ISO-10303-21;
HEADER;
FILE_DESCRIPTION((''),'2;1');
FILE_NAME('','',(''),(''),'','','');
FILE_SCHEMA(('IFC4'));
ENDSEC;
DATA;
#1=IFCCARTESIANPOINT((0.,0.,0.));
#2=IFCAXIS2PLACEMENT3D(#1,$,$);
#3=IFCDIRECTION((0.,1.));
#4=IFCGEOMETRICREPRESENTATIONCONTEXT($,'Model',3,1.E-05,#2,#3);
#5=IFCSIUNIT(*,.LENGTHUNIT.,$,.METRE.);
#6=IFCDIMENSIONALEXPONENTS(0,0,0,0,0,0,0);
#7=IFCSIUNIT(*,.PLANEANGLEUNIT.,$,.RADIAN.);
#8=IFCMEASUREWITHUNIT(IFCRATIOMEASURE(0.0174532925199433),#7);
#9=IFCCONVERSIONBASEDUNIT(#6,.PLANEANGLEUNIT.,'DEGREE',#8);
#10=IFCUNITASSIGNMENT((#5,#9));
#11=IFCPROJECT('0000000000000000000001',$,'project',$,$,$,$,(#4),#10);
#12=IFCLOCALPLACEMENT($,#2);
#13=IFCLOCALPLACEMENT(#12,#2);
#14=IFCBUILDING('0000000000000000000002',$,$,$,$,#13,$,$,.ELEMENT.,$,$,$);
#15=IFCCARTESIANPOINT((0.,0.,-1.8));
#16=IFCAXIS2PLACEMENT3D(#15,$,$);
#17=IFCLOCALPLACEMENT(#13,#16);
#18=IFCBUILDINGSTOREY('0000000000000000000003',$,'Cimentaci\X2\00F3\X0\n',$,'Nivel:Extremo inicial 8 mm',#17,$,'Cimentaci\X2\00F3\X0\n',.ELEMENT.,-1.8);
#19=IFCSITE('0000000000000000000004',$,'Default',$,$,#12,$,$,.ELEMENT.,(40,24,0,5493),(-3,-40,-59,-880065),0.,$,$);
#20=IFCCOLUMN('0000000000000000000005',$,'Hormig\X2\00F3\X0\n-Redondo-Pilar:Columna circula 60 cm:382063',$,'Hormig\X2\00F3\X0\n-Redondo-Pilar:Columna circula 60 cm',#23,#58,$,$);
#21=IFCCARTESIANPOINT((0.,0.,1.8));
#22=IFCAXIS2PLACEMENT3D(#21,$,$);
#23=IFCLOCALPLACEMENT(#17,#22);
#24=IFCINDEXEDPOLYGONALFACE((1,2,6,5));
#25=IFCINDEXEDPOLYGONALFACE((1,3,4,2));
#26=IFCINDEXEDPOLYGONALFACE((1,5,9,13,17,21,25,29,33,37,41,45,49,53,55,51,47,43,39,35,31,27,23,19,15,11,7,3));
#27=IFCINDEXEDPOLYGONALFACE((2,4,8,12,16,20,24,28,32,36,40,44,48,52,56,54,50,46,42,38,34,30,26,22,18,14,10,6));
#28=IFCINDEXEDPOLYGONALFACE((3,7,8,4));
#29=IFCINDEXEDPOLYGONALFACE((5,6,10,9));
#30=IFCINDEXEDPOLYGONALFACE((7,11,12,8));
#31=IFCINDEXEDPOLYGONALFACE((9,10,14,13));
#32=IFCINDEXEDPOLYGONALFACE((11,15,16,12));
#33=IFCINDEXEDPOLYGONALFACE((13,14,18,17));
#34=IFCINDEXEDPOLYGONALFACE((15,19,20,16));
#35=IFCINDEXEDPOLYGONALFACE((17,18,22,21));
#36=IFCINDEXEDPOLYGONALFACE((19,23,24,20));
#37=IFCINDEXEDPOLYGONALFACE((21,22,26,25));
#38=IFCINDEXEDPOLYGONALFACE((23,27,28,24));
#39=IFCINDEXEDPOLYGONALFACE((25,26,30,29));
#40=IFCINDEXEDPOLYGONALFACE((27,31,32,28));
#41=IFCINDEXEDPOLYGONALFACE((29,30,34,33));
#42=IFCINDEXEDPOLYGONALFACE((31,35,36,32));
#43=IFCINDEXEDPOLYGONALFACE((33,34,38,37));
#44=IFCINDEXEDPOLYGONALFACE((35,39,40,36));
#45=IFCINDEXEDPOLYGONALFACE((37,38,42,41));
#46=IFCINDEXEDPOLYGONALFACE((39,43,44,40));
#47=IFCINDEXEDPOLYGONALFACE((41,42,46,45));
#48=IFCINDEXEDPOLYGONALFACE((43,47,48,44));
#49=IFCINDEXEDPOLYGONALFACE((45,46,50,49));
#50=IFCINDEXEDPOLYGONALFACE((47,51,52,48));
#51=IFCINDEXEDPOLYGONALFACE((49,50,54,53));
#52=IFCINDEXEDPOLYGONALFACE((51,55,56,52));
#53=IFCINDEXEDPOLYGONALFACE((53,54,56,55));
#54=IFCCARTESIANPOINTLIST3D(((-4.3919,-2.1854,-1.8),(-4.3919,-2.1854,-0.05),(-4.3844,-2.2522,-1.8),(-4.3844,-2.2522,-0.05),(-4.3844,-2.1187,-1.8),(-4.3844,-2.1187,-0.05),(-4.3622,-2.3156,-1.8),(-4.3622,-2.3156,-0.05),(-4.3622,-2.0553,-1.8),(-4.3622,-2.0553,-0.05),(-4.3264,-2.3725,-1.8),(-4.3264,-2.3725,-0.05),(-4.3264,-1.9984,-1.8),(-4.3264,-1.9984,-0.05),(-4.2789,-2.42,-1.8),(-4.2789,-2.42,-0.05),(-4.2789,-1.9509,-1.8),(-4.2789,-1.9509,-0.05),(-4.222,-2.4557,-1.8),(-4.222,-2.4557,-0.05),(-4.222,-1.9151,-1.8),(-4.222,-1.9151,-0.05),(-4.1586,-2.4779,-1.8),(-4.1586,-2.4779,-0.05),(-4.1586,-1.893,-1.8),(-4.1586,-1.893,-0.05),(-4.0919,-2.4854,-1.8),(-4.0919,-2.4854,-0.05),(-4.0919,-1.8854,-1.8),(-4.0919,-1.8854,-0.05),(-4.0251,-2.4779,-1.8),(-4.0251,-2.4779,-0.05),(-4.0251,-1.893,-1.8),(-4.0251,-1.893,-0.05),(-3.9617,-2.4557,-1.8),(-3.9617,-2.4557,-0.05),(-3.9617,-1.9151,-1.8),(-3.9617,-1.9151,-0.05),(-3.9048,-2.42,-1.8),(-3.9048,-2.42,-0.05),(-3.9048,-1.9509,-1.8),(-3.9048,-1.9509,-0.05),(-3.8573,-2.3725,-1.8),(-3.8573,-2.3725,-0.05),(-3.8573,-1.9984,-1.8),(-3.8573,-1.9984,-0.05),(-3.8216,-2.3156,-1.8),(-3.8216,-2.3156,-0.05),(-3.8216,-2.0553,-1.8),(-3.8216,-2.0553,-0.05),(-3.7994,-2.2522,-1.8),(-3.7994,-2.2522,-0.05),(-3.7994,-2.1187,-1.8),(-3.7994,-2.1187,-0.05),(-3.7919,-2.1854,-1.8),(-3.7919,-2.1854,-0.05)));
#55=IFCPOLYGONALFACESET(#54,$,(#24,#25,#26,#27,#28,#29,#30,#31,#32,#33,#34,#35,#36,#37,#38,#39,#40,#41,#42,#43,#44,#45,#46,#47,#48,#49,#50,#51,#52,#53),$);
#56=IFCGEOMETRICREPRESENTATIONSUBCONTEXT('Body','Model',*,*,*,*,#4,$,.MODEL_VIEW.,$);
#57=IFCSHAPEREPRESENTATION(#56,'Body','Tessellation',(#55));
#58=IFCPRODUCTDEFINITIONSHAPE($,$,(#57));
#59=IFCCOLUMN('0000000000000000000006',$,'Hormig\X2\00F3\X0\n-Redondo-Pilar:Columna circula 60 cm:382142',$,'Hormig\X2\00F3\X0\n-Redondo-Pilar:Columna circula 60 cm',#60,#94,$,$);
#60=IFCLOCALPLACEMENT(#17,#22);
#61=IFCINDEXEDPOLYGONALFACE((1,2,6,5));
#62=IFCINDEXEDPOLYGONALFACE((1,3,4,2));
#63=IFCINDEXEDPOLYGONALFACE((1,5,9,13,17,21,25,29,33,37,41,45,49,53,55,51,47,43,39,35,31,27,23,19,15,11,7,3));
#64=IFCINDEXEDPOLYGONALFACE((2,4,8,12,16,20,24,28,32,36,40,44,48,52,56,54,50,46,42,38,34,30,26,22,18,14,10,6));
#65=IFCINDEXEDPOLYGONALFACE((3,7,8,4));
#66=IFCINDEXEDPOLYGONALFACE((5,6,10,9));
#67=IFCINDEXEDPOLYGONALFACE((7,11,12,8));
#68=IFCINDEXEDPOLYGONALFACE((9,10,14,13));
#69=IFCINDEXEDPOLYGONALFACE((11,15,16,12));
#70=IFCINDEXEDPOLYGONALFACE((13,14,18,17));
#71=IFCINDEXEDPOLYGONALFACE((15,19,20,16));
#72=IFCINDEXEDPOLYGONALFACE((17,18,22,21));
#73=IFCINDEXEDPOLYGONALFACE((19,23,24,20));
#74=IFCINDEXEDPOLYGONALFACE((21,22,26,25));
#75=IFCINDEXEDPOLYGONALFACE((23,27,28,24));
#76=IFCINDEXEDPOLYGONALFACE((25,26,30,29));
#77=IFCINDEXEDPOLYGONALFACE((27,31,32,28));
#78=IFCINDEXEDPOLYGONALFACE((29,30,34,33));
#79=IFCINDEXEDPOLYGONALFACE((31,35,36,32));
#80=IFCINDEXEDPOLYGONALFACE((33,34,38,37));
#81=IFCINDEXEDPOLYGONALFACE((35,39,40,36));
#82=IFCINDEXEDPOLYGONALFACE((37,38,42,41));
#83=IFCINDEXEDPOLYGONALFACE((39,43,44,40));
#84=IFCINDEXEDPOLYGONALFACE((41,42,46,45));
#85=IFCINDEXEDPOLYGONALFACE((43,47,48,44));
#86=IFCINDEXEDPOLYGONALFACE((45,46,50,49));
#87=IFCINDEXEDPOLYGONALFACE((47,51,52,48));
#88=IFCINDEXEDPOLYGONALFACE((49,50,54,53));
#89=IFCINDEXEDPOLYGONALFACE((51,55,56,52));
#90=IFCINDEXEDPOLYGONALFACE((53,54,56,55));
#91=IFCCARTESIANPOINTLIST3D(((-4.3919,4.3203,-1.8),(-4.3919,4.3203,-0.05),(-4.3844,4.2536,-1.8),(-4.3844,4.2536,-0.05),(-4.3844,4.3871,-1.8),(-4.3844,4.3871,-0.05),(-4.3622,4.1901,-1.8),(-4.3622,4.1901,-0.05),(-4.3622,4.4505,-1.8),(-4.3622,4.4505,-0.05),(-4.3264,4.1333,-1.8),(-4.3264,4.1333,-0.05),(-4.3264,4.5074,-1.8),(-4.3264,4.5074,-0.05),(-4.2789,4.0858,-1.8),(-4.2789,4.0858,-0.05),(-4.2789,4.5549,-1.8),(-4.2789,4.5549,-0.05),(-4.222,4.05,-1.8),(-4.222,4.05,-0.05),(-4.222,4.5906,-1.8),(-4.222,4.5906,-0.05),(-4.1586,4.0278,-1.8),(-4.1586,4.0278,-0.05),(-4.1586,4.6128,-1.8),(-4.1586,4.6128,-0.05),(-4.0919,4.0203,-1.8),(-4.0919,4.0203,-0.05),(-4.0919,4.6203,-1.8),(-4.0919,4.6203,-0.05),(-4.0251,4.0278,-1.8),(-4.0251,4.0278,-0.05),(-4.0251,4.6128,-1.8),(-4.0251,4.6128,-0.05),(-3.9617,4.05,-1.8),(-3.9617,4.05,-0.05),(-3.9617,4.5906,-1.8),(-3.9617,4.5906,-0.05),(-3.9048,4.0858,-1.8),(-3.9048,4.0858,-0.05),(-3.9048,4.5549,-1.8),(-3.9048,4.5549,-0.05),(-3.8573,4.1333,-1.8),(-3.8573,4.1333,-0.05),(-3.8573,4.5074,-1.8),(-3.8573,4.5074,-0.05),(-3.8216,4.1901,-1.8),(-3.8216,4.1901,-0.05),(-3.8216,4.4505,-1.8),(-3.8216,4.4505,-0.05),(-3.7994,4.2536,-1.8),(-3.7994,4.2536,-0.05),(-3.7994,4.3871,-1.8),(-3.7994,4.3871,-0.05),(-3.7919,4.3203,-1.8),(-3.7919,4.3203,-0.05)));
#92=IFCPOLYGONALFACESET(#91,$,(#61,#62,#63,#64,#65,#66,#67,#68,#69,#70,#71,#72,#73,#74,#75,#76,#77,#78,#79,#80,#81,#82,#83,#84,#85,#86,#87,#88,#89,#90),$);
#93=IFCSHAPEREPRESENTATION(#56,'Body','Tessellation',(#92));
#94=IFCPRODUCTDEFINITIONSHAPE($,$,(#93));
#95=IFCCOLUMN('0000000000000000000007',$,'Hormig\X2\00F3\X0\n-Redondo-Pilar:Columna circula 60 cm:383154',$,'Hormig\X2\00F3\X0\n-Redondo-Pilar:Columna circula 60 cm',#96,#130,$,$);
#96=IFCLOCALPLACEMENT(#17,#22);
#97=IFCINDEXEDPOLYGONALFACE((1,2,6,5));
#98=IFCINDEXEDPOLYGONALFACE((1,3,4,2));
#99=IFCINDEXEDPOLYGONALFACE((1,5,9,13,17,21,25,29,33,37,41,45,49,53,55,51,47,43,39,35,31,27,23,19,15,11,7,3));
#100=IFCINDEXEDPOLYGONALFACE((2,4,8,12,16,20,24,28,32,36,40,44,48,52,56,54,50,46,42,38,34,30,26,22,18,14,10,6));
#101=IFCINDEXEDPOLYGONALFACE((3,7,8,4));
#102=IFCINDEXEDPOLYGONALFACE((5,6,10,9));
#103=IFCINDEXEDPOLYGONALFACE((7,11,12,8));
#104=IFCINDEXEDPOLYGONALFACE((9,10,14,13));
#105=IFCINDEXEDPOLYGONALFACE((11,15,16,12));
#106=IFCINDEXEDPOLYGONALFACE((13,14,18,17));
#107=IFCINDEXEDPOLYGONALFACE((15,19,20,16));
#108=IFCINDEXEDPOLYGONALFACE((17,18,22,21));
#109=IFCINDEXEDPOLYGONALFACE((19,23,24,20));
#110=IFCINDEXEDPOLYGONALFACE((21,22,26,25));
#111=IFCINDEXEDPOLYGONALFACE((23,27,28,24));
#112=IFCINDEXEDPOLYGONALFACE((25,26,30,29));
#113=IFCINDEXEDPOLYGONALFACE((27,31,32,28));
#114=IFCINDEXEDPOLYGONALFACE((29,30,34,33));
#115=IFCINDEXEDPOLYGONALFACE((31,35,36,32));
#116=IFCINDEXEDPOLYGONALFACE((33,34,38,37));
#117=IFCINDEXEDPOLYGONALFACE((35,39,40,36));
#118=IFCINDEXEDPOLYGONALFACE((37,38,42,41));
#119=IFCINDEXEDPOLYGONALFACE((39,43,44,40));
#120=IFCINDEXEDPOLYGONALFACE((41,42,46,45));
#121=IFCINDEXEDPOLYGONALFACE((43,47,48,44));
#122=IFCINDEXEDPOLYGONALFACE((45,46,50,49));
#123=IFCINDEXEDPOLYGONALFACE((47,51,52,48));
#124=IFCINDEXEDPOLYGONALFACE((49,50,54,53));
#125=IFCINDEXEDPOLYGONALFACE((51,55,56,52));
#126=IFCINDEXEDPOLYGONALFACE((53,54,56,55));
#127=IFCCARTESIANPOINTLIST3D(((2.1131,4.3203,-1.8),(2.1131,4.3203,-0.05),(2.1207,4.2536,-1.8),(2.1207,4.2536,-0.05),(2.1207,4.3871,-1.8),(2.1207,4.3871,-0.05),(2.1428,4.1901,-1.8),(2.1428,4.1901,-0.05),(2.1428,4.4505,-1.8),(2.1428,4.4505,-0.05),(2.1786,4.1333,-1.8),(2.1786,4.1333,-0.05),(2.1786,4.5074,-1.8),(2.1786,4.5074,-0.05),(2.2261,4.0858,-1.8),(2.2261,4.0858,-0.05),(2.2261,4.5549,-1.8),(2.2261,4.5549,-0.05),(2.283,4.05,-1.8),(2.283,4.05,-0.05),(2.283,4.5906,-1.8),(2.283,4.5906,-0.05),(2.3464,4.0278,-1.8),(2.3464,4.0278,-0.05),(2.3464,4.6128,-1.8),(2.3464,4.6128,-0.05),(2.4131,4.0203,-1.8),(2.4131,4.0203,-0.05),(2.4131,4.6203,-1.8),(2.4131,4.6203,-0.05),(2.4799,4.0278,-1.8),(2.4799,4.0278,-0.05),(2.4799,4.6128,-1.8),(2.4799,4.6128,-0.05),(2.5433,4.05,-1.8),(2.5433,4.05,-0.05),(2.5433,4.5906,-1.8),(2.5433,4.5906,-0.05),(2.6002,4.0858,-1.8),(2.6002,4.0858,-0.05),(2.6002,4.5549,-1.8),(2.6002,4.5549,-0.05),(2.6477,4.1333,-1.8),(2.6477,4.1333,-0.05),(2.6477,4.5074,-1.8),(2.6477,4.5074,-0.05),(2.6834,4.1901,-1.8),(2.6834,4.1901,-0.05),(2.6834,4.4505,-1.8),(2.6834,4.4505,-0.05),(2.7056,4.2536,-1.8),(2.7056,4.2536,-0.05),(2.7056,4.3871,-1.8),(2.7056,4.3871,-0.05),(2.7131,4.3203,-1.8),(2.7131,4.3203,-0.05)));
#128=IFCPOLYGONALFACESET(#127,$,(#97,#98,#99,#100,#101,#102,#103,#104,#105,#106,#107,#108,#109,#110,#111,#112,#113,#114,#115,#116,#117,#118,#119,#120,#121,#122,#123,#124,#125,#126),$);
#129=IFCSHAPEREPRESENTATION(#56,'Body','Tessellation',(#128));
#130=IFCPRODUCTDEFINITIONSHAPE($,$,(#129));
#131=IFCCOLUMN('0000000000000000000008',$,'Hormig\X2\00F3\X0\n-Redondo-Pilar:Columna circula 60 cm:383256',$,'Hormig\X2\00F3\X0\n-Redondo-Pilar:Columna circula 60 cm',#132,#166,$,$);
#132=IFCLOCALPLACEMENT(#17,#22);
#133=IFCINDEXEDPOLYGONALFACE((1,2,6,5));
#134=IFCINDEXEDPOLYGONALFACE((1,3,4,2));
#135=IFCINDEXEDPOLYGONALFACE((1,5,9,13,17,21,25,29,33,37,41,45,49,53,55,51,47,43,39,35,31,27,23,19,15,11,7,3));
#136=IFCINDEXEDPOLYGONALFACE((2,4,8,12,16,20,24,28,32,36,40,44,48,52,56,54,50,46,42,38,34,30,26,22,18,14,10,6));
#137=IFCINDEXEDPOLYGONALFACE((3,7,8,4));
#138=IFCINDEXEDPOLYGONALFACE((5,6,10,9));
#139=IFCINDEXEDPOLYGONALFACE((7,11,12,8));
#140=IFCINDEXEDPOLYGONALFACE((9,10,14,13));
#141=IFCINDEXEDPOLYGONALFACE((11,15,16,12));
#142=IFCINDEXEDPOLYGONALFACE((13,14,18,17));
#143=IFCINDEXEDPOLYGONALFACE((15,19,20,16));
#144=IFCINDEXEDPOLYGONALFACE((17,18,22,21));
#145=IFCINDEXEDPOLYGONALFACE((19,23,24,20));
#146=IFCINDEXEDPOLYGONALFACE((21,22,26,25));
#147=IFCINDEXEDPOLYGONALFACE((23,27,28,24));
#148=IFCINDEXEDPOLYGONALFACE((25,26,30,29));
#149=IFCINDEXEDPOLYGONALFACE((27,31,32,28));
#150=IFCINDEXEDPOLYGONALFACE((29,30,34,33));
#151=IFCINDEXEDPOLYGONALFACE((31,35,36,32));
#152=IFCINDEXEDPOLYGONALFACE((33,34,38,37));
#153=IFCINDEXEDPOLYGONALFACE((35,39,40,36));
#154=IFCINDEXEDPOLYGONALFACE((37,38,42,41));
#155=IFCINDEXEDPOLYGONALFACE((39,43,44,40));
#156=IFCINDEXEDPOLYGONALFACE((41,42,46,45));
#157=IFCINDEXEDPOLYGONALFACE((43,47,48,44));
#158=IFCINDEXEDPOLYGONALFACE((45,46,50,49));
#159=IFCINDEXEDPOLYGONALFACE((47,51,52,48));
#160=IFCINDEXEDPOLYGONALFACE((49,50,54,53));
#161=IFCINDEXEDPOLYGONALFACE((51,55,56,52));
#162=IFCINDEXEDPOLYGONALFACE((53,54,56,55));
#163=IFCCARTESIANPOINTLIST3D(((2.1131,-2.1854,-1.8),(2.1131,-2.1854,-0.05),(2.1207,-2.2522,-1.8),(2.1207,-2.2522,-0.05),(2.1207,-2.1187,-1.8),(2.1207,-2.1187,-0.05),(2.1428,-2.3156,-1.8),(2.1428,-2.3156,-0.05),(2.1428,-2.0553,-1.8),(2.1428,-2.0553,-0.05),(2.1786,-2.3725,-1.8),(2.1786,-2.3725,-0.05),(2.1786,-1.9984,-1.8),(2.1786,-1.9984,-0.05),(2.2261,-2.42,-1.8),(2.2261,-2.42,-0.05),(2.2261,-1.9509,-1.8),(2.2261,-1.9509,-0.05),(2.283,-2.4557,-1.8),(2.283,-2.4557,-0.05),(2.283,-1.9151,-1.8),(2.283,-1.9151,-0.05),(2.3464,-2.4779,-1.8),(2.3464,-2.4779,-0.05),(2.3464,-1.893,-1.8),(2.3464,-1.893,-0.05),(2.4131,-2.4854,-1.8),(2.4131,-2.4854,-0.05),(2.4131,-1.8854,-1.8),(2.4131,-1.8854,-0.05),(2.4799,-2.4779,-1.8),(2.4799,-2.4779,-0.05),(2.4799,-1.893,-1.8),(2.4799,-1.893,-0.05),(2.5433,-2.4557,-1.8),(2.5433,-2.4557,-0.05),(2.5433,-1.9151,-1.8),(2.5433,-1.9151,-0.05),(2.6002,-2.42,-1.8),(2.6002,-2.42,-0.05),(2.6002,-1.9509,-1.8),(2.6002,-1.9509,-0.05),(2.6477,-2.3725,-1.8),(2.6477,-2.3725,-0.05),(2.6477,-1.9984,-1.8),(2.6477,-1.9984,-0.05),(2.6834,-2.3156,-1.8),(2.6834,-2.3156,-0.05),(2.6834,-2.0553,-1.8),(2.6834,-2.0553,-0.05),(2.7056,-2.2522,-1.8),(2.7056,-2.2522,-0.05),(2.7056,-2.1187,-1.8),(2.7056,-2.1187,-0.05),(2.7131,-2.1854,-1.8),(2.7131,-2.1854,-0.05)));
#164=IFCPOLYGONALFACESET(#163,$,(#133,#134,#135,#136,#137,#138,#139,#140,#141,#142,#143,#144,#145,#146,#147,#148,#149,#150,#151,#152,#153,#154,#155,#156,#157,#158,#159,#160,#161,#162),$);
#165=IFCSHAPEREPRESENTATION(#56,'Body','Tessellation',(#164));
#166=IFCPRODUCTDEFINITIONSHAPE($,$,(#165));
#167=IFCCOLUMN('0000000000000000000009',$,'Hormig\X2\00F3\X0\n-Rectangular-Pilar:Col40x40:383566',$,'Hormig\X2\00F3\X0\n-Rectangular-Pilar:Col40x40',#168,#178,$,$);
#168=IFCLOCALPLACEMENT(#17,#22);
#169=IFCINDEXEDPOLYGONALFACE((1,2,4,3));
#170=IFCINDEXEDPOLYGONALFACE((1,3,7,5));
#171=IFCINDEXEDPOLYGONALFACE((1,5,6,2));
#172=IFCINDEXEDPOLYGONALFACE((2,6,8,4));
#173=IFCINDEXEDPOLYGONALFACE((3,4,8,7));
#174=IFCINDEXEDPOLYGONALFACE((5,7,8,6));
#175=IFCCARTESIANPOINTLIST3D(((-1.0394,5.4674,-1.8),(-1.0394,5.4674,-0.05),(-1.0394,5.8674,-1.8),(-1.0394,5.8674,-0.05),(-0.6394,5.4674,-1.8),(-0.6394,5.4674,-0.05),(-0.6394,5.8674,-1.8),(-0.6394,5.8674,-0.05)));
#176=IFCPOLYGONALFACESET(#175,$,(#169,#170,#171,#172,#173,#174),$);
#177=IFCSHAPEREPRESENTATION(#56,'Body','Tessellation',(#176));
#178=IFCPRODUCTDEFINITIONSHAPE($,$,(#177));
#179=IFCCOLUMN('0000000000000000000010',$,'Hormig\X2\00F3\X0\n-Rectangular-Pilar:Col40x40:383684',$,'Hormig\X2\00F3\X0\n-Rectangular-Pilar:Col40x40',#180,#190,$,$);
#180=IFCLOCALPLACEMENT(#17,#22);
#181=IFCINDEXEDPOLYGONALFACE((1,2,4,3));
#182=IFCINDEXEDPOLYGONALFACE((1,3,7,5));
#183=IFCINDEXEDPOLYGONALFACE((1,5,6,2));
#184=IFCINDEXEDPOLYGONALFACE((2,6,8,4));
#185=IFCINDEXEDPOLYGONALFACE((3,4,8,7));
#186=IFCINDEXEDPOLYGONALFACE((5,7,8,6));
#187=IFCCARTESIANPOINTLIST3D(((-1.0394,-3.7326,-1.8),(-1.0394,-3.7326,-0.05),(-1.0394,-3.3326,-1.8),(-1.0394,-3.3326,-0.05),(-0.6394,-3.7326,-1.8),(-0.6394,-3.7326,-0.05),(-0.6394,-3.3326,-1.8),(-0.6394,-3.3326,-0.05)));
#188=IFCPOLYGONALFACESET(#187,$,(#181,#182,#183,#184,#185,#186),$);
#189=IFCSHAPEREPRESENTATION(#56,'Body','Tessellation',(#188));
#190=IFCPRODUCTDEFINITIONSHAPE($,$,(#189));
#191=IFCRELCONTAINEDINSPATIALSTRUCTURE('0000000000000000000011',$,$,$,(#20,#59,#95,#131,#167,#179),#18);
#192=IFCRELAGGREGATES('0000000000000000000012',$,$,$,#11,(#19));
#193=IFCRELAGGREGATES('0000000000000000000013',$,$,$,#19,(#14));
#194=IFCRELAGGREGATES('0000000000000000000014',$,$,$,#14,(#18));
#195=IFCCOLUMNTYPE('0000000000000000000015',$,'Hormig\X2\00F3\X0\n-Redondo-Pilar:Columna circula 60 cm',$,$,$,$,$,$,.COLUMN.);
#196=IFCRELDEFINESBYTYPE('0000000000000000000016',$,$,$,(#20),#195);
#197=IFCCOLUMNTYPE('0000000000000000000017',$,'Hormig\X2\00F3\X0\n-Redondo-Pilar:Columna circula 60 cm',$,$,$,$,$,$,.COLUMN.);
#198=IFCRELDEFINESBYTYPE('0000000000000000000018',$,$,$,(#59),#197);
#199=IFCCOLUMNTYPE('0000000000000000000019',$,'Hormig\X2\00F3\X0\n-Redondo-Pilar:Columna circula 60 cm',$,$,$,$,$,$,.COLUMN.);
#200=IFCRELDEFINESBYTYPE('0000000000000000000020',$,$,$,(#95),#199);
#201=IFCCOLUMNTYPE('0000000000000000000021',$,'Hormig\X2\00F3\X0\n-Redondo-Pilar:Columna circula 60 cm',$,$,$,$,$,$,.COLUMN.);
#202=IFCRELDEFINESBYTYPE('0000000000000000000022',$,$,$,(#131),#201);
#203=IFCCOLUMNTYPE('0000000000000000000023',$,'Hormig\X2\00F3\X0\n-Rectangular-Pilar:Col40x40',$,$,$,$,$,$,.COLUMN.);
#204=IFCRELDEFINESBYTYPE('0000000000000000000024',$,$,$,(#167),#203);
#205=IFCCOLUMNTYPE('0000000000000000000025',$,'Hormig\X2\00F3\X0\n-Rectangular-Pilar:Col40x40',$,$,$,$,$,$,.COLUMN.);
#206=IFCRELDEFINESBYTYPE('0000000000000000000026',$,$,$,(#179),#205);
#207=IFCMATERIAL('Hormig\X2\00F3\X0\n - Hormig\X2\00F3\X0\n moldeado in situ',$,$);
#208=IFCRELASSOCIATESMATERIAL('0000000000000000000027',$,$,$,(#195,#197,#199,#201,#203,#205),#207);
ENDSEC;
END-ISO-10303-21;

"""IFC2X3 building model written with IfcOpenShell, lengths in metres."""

from ifc_helpers import new_model, entity, si_unit, converted_unit, direction, frame, frame_2d, origin, origin_2d_with_axis, place, context, subcontext, project, spatial, rectangle, circle, extrude, source, transform, mapped, material, type_object, type_shapes, element, save


model = new_model("IFC2X3")

# Units and contexts
model_context = context("Model", 3, precision=1e-05, world=origin(), true_north=direction((0.0, 1.0)))
body_context = subcontext(model_context, "Body", "Model", "MODEL_VIEW")
ifc_project = project(units=[si_unit("LENGTHUNIT", "METRE"), converted_unit("PLANEANGLEUNIT", "DEGREE", entity("IfcRatioMeasure", 0.0174532925199433), si_unit("PLANEANGLEUNIT", "RADIAN"), dimensions=[0, 0, 0, 0, 0, 0, 0])], contexts=[model_context])

# Site, building, storey
site_placement = place(None, origin())
site = spatial("IfcSite", under=ifc_project, at=site_placement, Name="Default", CompositionType="ELEMENT", RefLatitude=(40, 24, 0, 5493), RefLongitude=(-3, -40, -59, -880065), RefElevation=0.0)
building_placement = place(site_placement, origin())
building = spatial("IfcBuilding", under=site, at=building_placement, CompositionType="ELEMENT")
storey_placement = place(building_placement, frame((0.0, 0.0, -1.8)))
storey = spatial("IfcBuildingStorey", under=building, at=storey_placement, Name="Cimentación", ObjectType="Nivel:Extremo inicial 8 mm", LongName="Cimentación", CompositionType="ELEMENT", Elevation=-1.8)

# Shared definitions
ifc_material_1 = material(Name="Hormigón - Hormigón moldeado in situ")

# Columns
column_type_1 = type_object("IfcColumnType", Name="Hormigón-Redondo-Pilar:Columna circula 60 cm", PredefinedType="COLUMN", material=ifc_material_1)
shared_shape_1 = source(origin(), body_context, "Body", "SweptSolid", [
    extrude(circle(Radius=0.3, at=frame_2d((0.0, 0.0), x_axis=(1.0, 0.0))), frame((-4.0919, -2.1854, -1.8)), (0.0, 0.0, 1.0), 1.75),
])
type_shapes(column_type_1, [shared_shape_1])
column_1_placement = place(storey_placement, frame((0.0, 0.0, 1.8)))
element("IfcColumn", 1, at=column_1_placement, inside=storey, type_object=column_type_1, Name="Hormigón-Redondo-Pilar:Columna circula 60 cm:382063", ObjectType="Hormigón-Redondo-Pilar:Columna circula 60 cm", context=body_context, shape_type="MappedRepresentation", body=[
    mapped(shared_shape_1, transform((0.0, 0.0, 0.0), scale=1.0)),
])
column_type_2 = type_object("IfcColumnType", Name="Hormigón-Redondo-Pilar:Columna circula 60 cm", PredefinedType="COLUMN", material=ifc_material_1)
shared_shape_2 = source(origin(), body_context, "Body", "SweptSolid", [
    extrude(circle(Radius=0.3, at=frame_2d((0.0, 0.0), x_axis=(1.0, 0.0))), frame((-4.0919, 4.3203, -1.8)), (0.0, 0.0, 1.0), 1.75),
])
type_shapes(column_type_2, [shared_shape_2])
column_2_placement = place(storey_placement, frame((0.0, 0.0, 1.8)))
element("IfcColumn", 2, at=column_2_placement, inside=storey, type_object=column_type_2, Name="Hormigón-Redondo-Pilar:Columna circula 60 cm:382142", ObjectType="Hormigón-Redondo-Pilar:Columna circula 60 cm", context=body_context, shape_type="MappedRepresentation", body=[
    mapped(shared_shape_2, transform((0.0, 0.0, 0.0), scale=1.0)),
])
column_type_3 = type_object("IfcColumnType", Name="Hormigón-Redondo-Pilar:Columna circula 60 cm", PredefinedType="COLUMN", material=ifc_material_1)
shared_shape_3 = source(origin(), body_context, "Body", "SweptSolid", [
    extrude(circle(Radius=0.3, at=frame_2d((0.0, 0.0), x_axis=(1.0, 0.0))), frame((2.4131, 4.3203, -1.8)), (0.0, 0.0, 1.0), 1.75),
])
type_shapes(column_type_3, [shared_shape_3])
column_3_placement = place(storey_placement, frame((0.0, 0.0, 1.8)))
element("IfcColumn", 3, at=column_3_placement, inside=storey, type_object=column_type_3, Name="Hormigón-Redondo-Pilar:Columna circula 60 cm:383154", ObjectType="Hormigón-Redondo-Pilar:Columna circula 60 cm", context=body_context, shape_type="MappedRepresentation", body=[
    mapped(shared_shape_3, transform((0.0, 0.0, 0.0), scale=1.0)),
])
column_type_4 = type_object("IfcColumnType", Name="Hormigón-Redondo-Pilar:Columna circula 60 cm", PredefinedType="COLUMN", material=ifc_material_1)
shared_shape_4 = source(origin(), body_context, "Body", "SweptSolid", [
    extrude(circle(Radius=0.3, at=frame_2d((0.0, 0.0), x_axis=(1.0, 0.0))), frame((2.4131, -2.1854, -1.8)), (0.0, 0.0, 1.0), 1.75),
])
type_shapes(column_type_4, [shared_shape_4])
column_4_placement = place(storey_placement, frame((0.0, 0.0, 1.8)))
element("IfcColumn", 4, at=column_4_placement, inside=storey, type_object=column_type_4, Name="Hormigón-Redondo-Pilar:Columna circula 60 cm:383256", ObjectType="Hormigón-Redondo-Pilar:Columna circula 60 cm", context=body_context, shape_type="MappedRepresentation", body=[
    mapped(shared_shape_4, transform((0.0, 0.0, 0.0), scale=1.0)),
])
column_type_5 = type_object("IfcColumnType", Name="Hormigón-Rectangular-Pilar:Col40x40", PredefinedType="COLUMN", material=ifc_material_1)
shared_shape_5 = source(origin(), body_context, "Body", "SweptSolid", [
    extrude(rectangle(XDim=0.4, YDim=0.4, at=origin_2d_with_axis()), frame((-0.8394, 5.6674, -1.8), z_axis=(0.0, 0.0, 1.0), x_axis=(0.0, -1.0, 0.0)), (0.0, 0.0, 1.0), 1.75),
])
type_shapes(column_type_5, [shared_shape_5])
column_5_placement = place(storey_placement, frame((0.0, 0.0, 1.8)))
element("IfcColumn", 5, at=column_5_placement, inside=storey, type_object=column_type_5, Name="Hormigón-Rectangular-Pilar:Col40x40:383566", ObjectType="Hormigón-Rectangular-Pilar:Col40x40", context=body_context, shape_type="MappedRepresentation", body=[
    mapped(shared_shape_5, transform((0.0, 0.0, 0.0), scale=1.0)),
])
column_type_6 = type_object("IfcColumnType", Name="Hormigón-Rectangular-Pilar:Col40x40", PredefinedType="COLUMN", material=ifc_material_1)
shared_shape_6 = source(origin(), body_context, "Body", "SweptSolid", [
    extrude(rectangle(XDim=0.4, YDim=0.4, at=origin_2d_with_axis()), frame((-0.8394, -3.5326, -1.8), z_axis=(0.0, 0.0, 1.0), x_axis=(0.0, -1.0, 0.0)), (0.0, 0.0, 1.0), 1.75),
])
type_shapes(column_type_6, [shared_shape_6])
column_6_placement = place(storey_placement, frame((0.0, 0.0, 1.8)))
element("IfcColumn", 6, at=column_6_placement, inside=storey, type_object=column_type_6, Name="Hormigón-Rectangular-Pilar:Col40x40:383684", ObjectType="Hormigón-Rectangular-Pilar:Col40x40", context=body_context, shape_type="MappedRepresentation", body=[
    mapped(shared_shape_6, transform((0.0, 0.0, 0.0), scale=1.0)),
])

save(model, "model.ifc")
